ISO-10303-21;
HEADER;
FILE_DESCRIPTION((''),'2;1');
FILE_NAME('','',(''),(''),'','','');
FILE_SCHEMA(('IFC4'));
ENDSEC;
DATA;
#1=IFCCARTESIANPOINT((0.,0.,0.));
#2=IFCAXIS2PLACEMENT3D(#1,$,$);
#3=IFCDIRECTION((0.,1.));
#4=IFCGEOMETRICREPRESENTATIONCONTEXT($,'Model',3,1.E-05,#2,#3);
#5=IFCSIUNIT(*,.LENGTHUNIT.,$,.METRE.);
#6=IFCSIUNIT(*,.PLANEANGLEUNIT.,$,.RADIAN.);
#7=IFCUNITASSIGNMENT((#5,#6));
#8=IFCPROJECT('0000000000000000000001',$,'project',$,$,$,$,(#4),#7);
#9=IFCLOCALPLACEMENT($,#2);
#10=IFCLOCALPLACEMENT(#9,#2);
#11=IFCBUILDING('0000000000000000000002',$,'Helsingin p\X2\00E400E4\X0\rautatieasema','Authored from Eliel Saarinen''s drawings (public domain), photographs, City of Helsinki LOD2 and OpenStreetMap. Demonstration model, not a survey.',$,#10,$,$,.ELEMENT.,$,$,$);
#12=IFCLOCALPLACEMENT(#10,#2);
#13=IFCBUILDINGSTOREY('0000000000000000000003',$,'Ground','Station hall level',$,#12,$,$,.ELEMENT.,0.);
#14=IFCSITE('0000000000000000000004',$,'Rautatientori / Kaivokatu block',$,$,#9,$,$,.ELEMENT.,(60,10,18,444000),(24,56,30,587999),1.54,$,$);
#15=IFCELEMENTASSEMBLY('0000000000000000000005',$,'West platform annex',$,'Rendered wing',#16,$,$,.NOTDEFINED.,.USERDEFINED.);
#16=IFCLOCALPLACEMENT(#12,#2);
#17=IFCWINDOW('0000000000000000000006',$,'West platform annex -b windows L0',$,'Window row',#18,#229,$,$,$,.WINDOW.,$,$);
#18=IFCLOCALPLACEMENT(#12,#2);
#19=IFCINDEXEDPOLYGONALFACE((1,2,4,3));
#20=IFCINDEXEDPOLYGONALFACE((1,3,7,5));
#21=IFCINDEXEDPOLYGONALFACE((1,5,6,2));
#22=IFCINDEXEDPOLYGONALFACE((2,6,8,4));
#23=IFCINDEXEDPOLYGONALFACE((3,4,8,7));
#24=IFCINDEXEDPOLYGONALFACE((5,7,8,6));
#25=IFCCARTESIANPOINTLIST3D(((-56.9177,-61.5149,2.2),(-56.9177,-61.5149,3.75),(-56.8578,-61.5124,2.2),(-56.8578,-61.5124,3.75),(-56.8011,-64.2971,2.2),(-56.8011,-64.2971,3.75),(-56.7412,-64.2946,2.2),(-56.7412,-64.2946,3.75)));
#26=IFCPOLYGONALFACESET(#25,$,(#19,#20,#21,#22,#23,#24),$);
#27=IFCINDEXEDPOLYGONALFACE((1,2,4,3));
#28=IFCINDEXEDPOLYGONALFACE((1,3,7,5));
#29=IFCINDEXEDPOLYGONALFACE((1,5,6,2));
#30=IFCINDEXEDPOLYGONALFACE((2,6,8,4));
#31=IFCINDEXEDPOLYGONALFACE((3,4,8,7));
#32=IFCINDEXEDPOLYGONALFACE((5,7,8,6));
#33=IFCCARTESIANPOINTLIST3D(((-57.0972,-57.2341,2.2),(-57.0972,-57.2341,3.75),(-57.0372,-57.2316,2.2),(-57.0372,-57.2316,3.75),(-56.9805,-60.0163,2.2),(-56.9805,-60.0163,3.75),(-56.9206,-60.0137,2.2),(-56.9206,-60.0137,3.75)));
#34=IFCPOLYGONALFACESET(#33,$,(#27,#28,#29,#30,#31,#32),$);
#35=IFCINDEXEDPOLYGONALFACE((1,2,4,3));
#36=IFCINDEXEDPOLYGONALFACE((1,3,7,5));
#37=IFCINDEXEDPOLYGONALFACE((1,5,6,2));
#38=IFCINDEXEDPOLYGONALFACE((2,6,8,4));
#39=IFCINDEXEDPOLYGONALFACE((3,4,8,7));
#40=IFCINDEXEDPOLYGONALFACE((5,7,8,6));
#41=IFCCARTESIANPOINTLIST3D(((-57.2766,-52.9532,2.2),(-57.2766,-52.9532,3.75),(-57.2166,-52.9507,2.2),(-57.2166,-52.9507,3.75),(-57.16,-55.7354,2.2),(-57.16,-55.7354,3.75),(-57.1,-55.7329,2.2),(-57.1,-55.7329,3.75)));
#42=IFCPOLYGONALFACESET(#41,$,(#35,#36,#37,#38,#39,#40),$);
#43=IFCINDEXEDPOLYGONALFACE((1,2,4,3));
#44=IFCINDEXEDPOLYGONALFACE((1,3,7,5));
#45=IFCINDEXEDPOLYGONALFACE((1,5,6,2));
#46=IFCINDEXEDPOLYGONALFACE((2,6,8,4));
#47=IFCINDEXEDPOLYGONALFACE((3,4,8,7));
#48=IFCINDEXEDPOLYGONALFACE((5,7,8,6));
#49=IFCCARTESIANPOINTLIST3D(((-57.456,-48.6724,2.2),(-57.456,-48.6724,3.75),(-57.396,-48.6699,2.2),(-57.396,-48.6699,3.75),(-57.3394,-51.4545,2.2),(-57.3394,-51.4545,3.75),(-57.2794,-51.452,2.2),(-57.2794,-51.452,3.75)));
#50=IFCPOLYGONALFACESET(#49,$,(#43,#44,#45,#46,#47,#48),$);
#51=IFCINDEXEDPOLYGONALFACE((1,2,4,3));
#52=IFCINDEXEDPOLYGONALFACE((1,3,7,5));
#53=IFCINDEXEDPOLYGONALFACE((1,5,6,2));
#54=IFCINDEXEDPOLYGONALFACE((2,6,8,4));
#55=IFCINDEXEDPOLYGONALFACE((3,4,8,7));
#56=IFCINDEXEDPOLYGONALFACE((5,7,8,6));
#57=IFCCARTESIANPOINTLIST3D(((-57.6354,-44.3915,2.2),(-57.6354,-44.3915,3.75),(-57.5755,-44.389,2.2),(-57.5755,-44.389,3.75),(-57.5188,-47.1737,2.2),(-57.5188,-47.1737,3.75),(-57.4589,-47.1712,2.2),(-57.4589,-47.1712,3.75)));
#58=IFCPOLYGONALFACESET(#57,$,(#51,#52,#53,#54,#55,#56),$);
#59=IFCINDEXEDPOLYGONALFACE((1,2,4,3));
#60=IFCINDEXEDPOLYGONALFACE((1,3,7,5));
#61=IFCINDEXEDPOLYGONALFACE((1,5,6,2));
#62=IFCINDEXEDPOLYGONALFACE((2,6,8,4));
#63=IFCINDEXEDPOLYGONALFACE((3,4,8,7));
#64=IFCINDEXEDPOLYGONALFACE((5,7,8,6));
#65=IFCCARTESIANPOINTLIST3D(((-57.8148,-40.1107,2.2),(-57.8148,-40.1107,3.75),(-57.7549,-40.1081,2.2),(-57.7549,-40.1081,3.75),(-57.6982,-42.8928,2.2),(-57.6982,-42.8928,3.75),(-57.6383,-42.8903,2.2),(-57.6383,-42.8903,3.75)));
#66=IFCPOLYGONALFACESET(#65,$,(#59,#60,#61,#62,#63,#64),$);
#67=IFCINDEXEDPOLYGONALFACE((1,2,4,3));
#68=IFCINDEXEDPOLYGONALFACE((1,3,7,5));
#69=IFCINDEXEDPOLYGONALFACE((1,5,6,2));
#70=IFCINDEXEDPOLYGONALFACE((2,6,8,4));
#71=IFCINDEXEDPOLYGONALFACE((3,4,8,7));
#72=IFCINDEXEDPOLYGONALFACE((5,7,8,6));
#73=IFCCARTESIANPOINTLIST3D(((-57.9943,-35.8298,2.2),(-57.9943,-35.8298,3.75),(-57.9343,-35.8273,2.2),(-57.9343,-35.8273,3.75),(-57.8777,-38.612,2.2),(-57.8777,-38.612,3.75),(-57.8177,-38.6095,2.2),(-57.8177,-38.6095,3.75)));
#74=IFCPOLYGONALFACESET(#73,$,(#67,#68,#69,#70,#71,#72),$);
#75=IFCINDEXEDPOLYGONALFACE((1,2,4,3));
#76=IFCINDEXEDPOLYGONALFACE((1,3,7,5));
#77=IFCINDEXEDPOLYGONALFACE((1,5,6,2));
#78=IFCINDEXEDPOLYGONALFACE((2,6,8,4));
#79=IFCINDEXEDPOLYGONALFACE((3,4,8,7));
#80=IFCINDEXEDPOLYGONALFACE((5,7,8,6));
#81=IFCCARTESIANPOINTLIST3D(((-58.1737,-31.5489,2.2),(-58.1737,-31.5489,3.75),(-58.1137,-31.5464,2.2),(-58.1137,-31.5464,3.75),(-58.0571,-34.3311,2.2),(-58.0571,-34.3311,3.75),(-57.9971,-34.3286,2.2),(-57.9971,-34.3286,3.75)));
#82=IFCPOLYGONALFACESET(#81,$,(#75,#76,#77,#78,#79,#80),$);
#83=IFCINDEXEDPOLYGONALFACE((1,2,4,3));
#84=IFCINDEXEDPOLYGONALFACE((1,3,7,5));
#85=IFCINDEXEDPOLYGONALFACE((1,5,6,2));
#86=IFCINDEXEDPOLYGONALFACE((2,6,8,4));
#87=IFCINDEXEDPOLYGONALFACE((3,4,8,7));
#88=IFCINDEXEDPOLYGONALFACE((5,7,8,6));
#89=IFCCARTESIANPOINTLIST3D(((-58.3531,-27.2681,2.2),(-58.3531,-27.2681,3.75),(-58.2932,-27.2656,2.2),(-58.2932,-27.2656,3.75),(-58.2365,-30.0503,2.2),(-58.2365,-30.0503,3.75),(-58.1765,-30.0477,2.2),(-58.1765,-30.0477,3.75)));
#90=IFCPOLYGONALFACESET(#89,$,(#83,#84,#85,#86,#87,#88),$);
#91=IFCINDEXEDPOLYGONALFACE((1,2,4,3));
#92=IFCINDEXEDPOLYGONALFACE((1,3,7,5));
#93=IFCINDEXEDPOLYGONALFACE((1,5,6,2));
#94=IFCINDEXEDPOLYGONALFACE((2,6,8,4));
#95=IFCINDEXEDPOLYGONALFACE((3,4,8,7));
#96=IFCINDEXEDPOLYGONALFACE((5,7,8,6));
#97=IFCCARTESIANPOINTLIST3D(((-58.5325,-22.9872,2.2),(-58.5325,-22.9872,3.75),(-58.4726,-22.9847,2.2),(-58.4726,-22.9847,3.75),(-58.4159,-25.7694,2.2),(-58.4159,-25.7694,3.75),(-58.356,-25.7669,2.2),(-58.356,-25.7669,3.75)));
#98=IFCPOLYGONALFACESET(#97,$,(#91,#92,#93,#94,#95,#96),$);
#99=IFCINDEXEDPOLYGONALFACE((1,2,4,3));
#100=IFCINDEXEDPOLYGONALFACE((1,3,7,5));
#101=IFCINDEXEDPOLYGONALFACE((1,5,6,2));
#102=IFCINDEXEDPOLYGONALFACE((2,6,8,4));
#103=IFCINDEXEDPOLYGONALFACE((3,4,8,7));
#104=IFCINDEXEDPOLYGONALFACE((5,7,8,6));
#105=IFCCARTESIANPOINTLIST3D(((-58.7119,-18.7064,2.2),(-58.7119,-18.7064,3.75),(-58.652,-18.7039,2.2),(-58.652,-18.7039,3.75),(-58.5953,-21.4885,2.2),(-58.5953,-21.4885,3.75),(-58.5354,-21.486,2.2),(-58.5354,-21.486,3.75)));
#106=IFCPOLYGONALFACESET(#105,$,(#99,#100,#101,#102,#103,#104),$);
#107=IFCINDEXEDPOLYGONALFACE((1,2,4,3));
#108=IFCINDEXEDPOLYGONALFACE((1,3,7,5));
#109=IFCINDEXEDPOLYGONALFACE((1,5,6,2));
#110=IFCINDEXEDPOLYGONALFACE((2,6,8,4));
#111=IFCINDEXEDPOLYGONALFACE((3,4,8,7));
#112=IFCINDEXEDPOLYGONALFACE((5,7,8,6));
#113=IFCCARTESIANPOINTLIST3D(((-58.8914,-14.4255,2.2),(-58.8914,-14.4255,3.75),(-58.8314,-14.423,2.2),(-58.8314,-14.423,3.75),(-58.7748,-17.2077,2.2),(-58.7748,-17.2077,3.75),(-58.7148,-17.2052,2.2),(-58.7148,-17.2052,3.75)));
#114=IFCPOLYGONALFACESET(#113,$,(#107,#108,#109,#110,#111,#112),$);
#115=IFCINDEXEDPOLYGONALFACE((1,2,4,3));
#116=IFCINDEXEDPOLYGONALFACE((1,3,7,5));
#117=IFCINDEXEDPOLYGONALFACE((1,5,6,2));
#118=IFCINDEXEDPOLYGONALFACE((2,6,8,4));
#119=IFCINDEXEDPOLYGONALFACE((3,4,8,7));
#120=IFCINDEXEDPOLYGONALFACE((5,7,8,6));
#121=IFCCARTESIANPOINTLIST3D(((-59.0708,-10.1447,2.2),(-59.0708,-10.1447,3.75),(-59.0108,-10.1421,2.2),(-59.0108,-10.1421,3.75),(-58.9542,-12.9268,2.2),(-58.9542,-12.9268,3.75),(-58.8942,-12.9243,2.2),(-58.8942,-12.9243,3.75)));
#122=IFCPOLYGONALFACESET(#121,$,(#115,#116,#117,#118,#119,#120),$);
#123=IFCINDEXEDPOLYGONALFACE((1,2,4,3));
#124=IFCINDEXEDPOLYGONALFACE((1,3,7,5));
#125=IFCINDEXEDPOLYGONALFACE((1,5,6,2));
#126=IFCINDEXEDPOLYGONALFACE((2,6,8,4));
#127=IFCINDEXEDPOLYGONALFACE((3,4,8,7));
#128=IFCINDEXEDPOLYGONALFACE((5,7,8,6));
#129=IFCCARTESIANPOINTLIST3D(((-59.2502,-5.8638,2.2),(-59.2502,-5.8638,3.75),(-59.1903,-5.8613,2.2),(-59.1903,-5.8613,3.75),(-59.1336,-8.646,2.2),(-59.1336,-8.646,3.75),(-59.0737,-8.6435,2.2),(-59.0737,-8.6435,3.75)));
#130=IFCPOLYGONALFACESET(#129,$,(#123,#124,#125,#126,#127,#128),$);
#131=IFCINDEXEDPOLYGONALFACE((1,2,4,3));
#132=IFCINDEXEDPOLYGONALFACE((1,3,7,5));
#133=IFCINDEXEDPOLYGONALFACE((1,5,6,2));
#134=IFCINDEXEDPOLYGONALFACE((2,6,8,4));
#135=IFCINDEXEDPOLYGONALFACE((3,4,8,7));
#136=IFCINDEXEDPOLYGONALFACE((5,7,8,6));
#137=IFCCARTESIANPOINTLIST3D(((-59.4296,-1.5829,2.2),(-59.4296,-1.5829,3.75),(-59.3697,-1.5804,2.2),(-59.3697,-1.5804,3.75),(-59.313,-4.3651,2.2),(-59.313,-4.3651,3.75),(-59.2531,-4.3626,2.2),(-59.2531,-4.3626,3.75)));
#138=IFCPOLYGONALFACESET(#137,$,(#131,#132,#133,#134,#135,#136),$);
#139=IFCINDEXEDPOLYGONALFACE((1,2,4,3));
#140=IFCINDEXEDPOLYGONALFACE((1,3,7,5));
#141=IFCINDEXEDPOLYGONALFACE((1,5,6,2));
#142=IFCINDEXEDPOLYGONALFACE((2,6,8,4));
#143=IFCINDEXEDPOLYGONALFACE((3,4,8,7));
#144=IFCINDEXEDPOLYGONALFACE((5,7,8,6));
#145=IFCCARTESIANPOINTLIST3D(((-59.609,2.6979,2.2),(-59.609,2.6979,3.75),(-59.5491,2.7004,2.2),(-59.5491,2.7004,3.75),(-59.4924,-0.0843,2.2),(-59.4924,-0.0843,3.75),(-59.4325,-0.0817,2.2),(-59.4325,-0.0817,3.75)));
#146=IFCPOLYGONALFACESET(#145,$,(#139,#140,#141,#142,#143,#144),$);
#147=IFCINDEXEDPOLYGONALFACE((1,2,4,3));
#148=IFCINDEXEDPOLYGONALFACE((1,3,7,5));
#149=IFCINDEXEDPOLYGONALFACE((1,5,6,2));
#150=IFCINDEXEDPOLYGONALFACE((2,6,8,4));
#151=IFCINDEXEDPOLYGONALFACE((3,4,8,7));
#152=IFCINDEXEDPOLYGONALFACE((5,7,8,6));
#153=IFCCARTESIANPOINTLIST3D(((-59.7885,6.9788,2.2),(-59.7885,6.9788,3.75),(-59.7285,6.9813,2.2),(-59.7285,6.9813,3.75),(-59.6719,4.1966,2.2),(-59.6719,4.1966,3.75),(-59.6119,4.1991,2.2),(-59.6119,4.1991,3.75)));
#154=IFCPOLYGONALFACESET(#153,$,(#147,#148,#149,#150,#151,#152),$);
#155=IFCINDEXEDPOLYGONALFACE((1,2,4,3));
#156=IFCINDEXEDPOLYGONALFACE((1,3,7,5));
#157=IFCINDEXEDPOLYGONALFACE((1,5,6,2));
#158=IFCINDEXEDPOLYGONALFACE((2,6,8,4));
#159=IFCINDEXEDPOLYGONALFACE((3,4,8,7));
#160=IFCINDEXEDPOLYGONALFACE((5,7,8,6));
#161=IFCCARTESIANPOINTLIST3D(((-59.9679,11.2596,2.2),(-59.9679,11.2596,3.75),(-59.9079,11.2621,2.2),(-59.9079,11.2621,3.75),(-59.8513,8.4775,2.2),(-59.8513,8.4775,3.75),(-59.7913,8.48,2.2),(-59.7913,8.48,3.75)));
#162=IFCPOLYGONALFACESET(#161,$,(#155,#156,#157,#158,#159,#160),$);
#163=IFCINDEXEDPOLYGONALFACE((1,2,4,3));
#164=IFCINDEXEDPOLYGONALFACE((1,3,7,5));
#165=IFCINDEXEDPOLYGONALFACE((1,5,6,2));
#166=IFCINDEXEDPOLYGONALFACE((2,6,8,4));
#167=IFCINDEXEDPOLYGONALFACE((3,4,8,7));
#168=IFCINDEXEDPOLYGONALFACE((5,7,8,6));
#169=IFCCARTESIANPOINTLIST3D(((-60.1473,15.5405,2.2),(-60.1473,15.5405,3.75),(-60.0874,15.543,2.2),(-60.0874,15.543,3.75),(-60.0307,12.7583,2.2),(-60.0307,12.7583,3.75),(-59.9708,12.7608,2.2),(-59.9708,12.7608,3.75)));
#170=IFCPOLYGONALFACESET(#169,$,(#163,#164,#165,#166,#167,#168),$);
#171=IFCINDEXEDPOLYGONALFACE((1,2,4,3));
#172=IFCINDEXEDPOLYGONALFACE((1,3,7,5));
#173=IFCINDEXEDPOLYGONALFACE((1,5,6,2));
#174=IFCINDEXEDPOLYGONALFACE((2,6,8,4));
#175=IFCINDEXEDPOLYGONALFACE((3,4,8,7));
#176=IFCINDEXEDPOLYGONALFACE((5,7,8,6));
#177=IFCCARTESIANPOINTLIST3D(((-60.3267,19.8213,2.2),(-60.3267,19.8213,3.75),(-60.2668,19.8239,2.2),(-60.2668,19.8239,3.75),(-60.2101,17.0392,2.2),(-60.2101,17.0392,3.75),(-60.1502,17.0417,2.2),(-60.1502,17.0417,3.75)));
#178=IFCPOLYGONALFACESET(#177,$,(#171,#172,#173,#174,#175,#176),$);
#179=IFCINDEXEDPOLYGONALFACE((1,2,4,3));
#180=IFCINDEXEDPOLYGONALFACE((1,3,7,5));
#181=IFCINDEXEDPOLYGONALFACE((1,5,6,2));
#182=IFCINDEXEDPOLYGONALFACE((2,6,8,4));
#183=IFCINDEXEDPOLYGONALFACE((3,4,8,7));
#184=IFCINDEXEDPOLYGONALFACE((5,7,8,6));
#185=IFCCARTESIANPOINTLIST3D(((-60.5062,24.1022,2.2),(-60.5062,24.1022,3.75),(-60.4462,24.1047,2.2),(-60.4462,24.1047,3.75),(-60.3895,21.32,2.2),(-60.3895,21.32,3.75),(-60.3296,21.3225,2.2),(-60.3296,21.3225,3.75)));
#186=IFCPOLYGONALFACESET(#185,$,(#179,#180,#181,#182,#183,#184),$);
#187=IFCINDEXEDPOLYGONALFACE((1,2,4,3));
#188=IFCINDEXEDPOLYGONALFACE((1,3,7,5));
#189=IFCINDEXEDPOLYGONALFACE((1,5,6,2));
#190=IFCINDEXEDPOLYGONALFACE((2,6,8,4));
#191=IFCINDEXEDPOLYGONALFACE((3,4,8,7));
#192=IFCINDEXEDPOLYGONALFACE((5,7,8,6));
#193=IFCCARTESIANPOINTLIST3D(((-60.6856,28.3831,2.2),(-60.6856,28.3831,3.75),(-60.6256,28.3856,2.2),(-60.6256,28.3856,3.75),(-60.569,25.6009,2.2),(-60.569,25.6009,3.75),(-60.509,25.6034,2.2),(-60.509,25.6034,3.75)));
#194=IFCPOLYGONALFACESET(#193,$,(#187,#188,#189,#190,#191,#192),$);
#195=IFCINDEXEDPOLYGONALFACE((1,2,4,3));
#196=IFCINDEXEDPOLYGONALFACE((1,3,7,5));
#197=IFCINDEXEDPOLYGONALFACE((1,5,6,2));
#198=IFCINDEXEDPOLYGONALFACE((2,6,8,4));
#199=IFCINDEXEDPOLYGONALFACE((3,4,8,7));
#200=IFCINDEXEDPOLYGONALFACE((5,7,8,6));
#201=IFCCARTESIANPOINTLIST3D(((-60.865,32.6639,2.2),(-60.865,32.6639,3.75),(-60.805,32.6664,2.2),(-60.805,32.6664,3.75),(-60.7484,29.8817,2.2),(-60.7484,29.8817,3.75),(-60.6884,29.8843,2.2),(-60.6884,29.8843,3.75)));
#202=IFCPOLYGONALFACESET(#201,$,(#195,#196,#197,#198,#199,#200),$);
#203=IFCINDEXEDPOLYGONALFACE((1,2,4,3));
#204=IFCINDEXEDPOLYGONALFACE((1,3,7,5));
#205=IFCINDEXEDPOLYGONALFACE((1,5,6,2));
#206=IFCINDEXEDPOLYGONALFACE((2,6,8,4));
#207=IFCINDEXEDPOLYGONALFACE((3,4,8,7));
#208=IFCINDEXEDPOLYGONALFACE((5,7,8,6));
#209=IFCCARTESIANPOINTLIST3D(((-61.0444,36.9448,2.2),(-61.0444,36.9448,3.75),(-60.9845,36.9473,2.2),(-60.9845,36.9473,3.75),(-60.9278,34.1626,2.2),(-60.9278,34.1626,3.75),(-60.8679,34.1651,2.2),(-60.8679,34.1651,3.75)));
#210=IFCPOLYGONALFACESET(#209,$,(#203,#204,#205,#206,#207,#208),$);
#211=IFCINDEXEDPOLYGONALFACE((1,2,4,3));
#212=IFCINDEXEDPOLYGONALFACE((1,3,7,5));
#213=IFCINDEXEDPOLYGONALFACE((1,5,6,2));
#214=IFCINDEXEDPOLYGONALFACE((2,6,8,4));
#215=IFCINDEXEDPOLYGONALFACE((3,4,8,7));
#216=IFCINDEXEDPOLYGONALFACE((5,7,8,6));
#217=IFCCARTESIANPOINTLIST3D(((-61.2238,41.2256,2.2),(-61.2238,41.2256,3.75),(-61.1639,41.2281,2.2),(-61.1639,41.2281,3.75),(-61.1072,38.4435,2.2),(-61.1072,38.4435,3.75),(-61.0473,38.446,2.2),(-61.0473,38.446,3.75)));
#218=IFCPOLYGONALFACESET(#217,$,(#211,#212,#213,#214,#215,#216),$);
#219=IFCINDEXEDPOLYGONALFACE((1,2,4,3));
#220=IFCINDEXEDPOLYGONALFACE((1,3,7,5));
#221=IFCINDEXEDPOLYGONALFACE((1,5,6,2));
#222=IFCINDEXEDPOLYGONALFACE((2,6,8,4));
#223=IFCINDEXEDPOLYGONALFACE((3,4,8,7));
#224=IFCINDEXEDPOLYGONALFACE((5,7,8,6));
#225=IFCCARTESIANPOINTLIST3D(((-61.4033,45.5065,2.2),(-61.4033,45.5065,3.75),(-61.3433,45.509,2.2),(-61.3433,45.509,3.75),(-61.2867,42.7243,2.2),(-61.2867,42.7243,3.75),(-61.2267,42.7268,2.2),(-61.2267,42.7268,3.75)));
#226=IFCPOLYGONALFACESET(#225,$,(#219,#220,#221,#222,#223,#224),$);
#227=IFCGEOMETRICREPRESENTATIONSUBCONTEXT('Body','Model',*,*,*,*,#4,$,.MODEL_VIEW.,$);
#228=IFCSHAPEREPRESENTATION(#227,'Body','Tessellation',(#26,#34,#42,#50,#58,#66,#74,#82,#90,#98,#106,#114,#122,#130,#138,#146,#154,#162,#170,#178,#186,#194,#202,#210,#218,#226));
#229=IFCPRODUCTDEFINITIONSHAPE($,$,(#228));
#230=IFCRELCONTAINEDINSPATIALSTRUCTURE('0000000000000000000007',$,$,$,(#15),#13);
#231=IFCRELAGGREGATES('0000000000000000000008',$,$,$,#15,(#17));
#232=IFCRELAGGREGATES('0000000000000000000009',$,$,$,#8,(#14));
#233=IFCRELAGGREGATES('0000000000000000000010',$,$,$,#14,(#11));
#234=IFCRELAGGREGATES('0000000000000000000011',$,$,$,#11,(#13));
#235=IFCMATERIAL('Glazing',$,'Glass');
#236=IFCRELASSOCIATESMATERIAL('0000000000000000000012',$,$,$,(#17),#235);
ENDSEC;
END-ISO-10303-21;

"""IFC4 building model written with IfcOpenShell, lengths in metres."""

from ifc_helpers import new_model, si_unit, direction, frame, frame_2d, origin, place, context, subcontext, project, spatial, rectangle, extrude, material, element, aggregate, save


model = new_model("IFC4")

# Units and contexts
model_context = context("Model", 3, precision=1e-05, world=origin(), true_north=direction((0.0, 1.0)))
body_context = subcontext(model_context, "Body", "Model", "MODEL_VIEW")
ifc_project = project(units=[si_unit("LENGTHUNIT", "METRE"), si_unit("PLANEANGLEUNIT", "RADIAN")], contexts=[model_context])

# Site, building, storey
site_placement = place(None, origin())
site = spatial("IfcSite", under=ifc_project, at=site_placement, Name="Rautatientori / Kaivokatu block", CompositionType="ELEMENT", RefLatitude=(60, 10, 18, 444000), RefLongitude=(24, 56, 30, 587999), RefElevation=1.54)
building_placement = place(site_placement, origin())
building = spatial("IfcBuilding", under=site, at=building_placement, Name="Helsingin päärautatieasema", Description="Authored from Eliel Saarinen's drawings (public domain), photographs, City of Helsinki LOD2 and OpenStreetMap. Demonstration model, not a survey.", CompositionType="ELEMENT")
storey_placement = place(building_placement, origin())
storey = spatial("IfcBuildingStorey", under=building, at=storey_placement, Name="Ground", Description="Station hall level", CompositionType="ELEMENT", Elevation=0.0)

# Element assembly
assembly_1_placement = place(building_placement, origin())
assembly_1 = element("IfcElementAssembly", 1, at=assembly_1_placement, inside=storey, Name="West platform annex", ObjectType="Rendered wing", AssemblyPlace="NOTDEFINED", PredefinedType="USERDEFINED")

# Shared definitions
ifc_material_1 = material(Name="Glazing", Category="Glass")

# Window
window_1_placement = place(building_placement, origin())
window_1 = element("IfcWindow", 2, at=window_1_placement, material=ifc_material_1, Name="West platform annex -b windows L0", ObjectType="Window row", PredefinedType="WINDOW", context=body_context, shape_type="SweptSolid", body=[
    extrude(rectangle(XDim=2.7846, YDim=0.06, at=frame_2d((0.0, 0.0), x_axis=(-0.041876, 0.999123))), frame((-56.8295, -62.9048, 2.2)), (0.0, 0.0, 1.0), 1.55),
    extrude(rectangle(XDim=2.7846, YDim=0.06, at=frame_2d((0.0, 0.0), x_axis=(-0.041876, 0.999123))), frame((-57.0089, -58.6239, 2.2)), (0.0, 0.0, 1.0), 1.55),
    extrude(rectangle(XDim=2.7846, YDim=0.06, at=frame_2d((0.0, 0.0), x_axis=(-0.041876, 0.999123))), frame((-57.1883, -54.3431, 2.2)), (0.0, 0.0, 1.0), 1.55),
    extrude(rectangle(XDim=2.7846, YDim=0.06, at=frame_2d((0.0, 0.0), x_axis=(-0.041876, 0.999123))), frame((-57.3677, -50.0622, 2.2)), (0.0, 0.0, 1.0), 1.55),
    extrude(rectangle(XDim=2.7846, YDim=0.06, at=frame_2d((0.0, 0.0), x_axis=(-0.041876, 0.999123))), frame((-57.5471, -45.7813, 2.2)), (0.0, 0.0, 1.0), 1.55),
    extrude(rectangle(XDim=2.7846, YDim=0.06, at=frame_2d((0.0, 0.0), x_axis=(-0.041876, 0.999123))), frame((-57.7266, -41.5005, 2.2)), (0.0, 0.0, 1.0), 1.55),
    extrude(rectangle(XDim=2.7846, YDim=0.06, at=frame_2d((0.0, 0.0), x_axis=(-0.041876, 0.999123))), frame((-57.906, -37.2196, 2.2)), (0.0, 0.0, 1.0), 1.55),
    extrude(rectangle(XDim=2.7846, YDim=0.06, at=frame_2d((0.0, 0.0), x_axis=(-0.041876, 0.999123))), frame((-58.0854, -32.9388, 2.2)), (0.0, 0.0, 1.0), 1.55),
    extrude(rectangle(XDim=2.7846, YDim=0.06, at=frame_2d((0.0, 0.0), x_axis=(-0.041876, 0.999123))), frame((-58.2648, -28.6579, 2.2)), (0.0, 0.0, 1.0), 1.55),
    extrude(rectangle(XDim=2.7846, YDim=0.06, at=frame_2d((0.0, 0.0), x_axis=(-0.041876, 0.999123))), frame((-58.4442, -24.3771, 2.2)), (0.0, 0.0, 1.0), 1.55),
    extrude(rectangle(XDim=2.7846, YDim=0.06, at=frame_2d((0.0, 0.0), x_axis=(-0.041876, 0.999123))), frame((-58.6237, -20.0962, 2.2)), (0.0, 0.0, 1.0), 1.55),
    extrude(rectangle(XDim=2.7846, YDim=0.06, at=frame_2d((0.0, 0.0), x_axis=(-0.041876, 0.999123))), frame((-58.8031, -15.8153, 2.2)), (0.0, 0.0, 1.0), 1.55),
    extrude(rectangle(XDim=2.7846, YDim=0.06, at=frame_2d((0.0, 0.0), x_axis=(-0.041876, 0.999123))), frame((-58.9825, -11.5345, 2.2)), (0.0, 0.0, 1.0), 1.55),
    extrude(rectangle(XDim=2.7846, YDim=0.06, at=frame_2d((0.0, 0.0), x_axis=(-0.041876, 0.999123))), frame((-59.1619, -7.2536, 2.2)), (0.0, 0.0, 1.0), 1.55),
    extrude(rectangle(XDim=2.7846, YDim=0.06, at=frame_2d((0.0, 0.0), x_axis=(-0.041876, 0.999123))), frame((-59.3414, -2.9728, 2.2)), (0.0, 0.0, 1.0), 1.55),
    extrude(rectangle(XDim=2.7846, YDim=0.06, at=frame_2d((0.0, 0.0), x_axis=(-0.041876, 0.999123))), frame((-59.5208, 1.3081, 2.2)), (0.0, 0.0, 1.0), 1.55),
    extrude(rectangle(XDim=2.7846, YDim=0.06, at=frame_2d((0.0, 0.0), x_axis=(-0.041876, 0.999123))), frame((-59.7002, 5.5889, 2.2)), (0.0, 0.0, 1.0), 1.55),
    extrude(rectangle(XDim=2.7846, YDim=0.06, at=frame_2d((0.0, 0.0), x_axis=(-0.041876, 0.999123))), frame((-59.8796, 9.8698, 2.2)), (0.0, 0.0, 1.0), 1.55),
    extrude(rectangle(XDim=2.7846, YDim=0.06, at=frame_2d((0.0, 0.0), x_axis=(-0.041876, 0.999123))), frame((-60.059, 14.1507, 2.2)), (0.0, 0.0, 1.0), 1.55),
    extrude(rectangle(XDim=2.7846, YDim=0.06, at=frame_2d((0.0, 0.0), x_axis=(-0.041876, 0.999123))), frame((-60.2385, 18.4315, 2.2)), (0.0, 0.0, 1.0), 1.55),
    extrude(rectangle(XDim=2.7846, YDim=0.06, at=frame_2d((0.0, 0.0), x_axis=(-0.041876, 0.999123))), frame((-60.4179, 22.7124, 2.2)), (0.0, 0.0, 1.0), 1.55),
    extrude(rectangle(XDim=2.7846, YDim=0.06, at=frame_2d((0.0, 0.0), x_axis=(-0.041876, 0.999123))), frame((-60.5973, 26.9932, 2.2)), (0.0, 0.0, 1.0), 1.55),
    extrude(rectangle(XDim=2.7846, YDim=0.06, at=frame_2d((0.0, 0.0), x_axis=(-0.041876, 0.999123))), frame((-60.7767, 31.2741, 2.2)), (0.0, 0.0, 1.0), 1.55),
    extrude(rectangle(XDim=2.7846, YDim=0.06, at=frame_2d((0.0, 0.0), x_axis=(-0.041876, 0.999123))), frame((-60.9561, 35.5549, 2.2)), (0.0, 0.0, 1.0), 1.55),
    extrude(rectangle(XDim=2.7846, YDim=0.06, at=frame_2d((0.0, 0.0), x_axis=(-0.041876, 0.999123))), frame((-61.1356, 39.8358, 2.2)), (0.0, 0.0, 1.0), 1.55),
    extrude(rectangle(XDim=2.7846, YDim=0.06, at=frame_2d((0.0, 0.0), x_axis=(-0.041876, 0.999123))), frame((-61.315, 44.1167, 2.2)), (0.0, 0.0, 1.0), 1.55),
])

aggregate(assembly_1, [window_1])

save(model, "model.ifc")
